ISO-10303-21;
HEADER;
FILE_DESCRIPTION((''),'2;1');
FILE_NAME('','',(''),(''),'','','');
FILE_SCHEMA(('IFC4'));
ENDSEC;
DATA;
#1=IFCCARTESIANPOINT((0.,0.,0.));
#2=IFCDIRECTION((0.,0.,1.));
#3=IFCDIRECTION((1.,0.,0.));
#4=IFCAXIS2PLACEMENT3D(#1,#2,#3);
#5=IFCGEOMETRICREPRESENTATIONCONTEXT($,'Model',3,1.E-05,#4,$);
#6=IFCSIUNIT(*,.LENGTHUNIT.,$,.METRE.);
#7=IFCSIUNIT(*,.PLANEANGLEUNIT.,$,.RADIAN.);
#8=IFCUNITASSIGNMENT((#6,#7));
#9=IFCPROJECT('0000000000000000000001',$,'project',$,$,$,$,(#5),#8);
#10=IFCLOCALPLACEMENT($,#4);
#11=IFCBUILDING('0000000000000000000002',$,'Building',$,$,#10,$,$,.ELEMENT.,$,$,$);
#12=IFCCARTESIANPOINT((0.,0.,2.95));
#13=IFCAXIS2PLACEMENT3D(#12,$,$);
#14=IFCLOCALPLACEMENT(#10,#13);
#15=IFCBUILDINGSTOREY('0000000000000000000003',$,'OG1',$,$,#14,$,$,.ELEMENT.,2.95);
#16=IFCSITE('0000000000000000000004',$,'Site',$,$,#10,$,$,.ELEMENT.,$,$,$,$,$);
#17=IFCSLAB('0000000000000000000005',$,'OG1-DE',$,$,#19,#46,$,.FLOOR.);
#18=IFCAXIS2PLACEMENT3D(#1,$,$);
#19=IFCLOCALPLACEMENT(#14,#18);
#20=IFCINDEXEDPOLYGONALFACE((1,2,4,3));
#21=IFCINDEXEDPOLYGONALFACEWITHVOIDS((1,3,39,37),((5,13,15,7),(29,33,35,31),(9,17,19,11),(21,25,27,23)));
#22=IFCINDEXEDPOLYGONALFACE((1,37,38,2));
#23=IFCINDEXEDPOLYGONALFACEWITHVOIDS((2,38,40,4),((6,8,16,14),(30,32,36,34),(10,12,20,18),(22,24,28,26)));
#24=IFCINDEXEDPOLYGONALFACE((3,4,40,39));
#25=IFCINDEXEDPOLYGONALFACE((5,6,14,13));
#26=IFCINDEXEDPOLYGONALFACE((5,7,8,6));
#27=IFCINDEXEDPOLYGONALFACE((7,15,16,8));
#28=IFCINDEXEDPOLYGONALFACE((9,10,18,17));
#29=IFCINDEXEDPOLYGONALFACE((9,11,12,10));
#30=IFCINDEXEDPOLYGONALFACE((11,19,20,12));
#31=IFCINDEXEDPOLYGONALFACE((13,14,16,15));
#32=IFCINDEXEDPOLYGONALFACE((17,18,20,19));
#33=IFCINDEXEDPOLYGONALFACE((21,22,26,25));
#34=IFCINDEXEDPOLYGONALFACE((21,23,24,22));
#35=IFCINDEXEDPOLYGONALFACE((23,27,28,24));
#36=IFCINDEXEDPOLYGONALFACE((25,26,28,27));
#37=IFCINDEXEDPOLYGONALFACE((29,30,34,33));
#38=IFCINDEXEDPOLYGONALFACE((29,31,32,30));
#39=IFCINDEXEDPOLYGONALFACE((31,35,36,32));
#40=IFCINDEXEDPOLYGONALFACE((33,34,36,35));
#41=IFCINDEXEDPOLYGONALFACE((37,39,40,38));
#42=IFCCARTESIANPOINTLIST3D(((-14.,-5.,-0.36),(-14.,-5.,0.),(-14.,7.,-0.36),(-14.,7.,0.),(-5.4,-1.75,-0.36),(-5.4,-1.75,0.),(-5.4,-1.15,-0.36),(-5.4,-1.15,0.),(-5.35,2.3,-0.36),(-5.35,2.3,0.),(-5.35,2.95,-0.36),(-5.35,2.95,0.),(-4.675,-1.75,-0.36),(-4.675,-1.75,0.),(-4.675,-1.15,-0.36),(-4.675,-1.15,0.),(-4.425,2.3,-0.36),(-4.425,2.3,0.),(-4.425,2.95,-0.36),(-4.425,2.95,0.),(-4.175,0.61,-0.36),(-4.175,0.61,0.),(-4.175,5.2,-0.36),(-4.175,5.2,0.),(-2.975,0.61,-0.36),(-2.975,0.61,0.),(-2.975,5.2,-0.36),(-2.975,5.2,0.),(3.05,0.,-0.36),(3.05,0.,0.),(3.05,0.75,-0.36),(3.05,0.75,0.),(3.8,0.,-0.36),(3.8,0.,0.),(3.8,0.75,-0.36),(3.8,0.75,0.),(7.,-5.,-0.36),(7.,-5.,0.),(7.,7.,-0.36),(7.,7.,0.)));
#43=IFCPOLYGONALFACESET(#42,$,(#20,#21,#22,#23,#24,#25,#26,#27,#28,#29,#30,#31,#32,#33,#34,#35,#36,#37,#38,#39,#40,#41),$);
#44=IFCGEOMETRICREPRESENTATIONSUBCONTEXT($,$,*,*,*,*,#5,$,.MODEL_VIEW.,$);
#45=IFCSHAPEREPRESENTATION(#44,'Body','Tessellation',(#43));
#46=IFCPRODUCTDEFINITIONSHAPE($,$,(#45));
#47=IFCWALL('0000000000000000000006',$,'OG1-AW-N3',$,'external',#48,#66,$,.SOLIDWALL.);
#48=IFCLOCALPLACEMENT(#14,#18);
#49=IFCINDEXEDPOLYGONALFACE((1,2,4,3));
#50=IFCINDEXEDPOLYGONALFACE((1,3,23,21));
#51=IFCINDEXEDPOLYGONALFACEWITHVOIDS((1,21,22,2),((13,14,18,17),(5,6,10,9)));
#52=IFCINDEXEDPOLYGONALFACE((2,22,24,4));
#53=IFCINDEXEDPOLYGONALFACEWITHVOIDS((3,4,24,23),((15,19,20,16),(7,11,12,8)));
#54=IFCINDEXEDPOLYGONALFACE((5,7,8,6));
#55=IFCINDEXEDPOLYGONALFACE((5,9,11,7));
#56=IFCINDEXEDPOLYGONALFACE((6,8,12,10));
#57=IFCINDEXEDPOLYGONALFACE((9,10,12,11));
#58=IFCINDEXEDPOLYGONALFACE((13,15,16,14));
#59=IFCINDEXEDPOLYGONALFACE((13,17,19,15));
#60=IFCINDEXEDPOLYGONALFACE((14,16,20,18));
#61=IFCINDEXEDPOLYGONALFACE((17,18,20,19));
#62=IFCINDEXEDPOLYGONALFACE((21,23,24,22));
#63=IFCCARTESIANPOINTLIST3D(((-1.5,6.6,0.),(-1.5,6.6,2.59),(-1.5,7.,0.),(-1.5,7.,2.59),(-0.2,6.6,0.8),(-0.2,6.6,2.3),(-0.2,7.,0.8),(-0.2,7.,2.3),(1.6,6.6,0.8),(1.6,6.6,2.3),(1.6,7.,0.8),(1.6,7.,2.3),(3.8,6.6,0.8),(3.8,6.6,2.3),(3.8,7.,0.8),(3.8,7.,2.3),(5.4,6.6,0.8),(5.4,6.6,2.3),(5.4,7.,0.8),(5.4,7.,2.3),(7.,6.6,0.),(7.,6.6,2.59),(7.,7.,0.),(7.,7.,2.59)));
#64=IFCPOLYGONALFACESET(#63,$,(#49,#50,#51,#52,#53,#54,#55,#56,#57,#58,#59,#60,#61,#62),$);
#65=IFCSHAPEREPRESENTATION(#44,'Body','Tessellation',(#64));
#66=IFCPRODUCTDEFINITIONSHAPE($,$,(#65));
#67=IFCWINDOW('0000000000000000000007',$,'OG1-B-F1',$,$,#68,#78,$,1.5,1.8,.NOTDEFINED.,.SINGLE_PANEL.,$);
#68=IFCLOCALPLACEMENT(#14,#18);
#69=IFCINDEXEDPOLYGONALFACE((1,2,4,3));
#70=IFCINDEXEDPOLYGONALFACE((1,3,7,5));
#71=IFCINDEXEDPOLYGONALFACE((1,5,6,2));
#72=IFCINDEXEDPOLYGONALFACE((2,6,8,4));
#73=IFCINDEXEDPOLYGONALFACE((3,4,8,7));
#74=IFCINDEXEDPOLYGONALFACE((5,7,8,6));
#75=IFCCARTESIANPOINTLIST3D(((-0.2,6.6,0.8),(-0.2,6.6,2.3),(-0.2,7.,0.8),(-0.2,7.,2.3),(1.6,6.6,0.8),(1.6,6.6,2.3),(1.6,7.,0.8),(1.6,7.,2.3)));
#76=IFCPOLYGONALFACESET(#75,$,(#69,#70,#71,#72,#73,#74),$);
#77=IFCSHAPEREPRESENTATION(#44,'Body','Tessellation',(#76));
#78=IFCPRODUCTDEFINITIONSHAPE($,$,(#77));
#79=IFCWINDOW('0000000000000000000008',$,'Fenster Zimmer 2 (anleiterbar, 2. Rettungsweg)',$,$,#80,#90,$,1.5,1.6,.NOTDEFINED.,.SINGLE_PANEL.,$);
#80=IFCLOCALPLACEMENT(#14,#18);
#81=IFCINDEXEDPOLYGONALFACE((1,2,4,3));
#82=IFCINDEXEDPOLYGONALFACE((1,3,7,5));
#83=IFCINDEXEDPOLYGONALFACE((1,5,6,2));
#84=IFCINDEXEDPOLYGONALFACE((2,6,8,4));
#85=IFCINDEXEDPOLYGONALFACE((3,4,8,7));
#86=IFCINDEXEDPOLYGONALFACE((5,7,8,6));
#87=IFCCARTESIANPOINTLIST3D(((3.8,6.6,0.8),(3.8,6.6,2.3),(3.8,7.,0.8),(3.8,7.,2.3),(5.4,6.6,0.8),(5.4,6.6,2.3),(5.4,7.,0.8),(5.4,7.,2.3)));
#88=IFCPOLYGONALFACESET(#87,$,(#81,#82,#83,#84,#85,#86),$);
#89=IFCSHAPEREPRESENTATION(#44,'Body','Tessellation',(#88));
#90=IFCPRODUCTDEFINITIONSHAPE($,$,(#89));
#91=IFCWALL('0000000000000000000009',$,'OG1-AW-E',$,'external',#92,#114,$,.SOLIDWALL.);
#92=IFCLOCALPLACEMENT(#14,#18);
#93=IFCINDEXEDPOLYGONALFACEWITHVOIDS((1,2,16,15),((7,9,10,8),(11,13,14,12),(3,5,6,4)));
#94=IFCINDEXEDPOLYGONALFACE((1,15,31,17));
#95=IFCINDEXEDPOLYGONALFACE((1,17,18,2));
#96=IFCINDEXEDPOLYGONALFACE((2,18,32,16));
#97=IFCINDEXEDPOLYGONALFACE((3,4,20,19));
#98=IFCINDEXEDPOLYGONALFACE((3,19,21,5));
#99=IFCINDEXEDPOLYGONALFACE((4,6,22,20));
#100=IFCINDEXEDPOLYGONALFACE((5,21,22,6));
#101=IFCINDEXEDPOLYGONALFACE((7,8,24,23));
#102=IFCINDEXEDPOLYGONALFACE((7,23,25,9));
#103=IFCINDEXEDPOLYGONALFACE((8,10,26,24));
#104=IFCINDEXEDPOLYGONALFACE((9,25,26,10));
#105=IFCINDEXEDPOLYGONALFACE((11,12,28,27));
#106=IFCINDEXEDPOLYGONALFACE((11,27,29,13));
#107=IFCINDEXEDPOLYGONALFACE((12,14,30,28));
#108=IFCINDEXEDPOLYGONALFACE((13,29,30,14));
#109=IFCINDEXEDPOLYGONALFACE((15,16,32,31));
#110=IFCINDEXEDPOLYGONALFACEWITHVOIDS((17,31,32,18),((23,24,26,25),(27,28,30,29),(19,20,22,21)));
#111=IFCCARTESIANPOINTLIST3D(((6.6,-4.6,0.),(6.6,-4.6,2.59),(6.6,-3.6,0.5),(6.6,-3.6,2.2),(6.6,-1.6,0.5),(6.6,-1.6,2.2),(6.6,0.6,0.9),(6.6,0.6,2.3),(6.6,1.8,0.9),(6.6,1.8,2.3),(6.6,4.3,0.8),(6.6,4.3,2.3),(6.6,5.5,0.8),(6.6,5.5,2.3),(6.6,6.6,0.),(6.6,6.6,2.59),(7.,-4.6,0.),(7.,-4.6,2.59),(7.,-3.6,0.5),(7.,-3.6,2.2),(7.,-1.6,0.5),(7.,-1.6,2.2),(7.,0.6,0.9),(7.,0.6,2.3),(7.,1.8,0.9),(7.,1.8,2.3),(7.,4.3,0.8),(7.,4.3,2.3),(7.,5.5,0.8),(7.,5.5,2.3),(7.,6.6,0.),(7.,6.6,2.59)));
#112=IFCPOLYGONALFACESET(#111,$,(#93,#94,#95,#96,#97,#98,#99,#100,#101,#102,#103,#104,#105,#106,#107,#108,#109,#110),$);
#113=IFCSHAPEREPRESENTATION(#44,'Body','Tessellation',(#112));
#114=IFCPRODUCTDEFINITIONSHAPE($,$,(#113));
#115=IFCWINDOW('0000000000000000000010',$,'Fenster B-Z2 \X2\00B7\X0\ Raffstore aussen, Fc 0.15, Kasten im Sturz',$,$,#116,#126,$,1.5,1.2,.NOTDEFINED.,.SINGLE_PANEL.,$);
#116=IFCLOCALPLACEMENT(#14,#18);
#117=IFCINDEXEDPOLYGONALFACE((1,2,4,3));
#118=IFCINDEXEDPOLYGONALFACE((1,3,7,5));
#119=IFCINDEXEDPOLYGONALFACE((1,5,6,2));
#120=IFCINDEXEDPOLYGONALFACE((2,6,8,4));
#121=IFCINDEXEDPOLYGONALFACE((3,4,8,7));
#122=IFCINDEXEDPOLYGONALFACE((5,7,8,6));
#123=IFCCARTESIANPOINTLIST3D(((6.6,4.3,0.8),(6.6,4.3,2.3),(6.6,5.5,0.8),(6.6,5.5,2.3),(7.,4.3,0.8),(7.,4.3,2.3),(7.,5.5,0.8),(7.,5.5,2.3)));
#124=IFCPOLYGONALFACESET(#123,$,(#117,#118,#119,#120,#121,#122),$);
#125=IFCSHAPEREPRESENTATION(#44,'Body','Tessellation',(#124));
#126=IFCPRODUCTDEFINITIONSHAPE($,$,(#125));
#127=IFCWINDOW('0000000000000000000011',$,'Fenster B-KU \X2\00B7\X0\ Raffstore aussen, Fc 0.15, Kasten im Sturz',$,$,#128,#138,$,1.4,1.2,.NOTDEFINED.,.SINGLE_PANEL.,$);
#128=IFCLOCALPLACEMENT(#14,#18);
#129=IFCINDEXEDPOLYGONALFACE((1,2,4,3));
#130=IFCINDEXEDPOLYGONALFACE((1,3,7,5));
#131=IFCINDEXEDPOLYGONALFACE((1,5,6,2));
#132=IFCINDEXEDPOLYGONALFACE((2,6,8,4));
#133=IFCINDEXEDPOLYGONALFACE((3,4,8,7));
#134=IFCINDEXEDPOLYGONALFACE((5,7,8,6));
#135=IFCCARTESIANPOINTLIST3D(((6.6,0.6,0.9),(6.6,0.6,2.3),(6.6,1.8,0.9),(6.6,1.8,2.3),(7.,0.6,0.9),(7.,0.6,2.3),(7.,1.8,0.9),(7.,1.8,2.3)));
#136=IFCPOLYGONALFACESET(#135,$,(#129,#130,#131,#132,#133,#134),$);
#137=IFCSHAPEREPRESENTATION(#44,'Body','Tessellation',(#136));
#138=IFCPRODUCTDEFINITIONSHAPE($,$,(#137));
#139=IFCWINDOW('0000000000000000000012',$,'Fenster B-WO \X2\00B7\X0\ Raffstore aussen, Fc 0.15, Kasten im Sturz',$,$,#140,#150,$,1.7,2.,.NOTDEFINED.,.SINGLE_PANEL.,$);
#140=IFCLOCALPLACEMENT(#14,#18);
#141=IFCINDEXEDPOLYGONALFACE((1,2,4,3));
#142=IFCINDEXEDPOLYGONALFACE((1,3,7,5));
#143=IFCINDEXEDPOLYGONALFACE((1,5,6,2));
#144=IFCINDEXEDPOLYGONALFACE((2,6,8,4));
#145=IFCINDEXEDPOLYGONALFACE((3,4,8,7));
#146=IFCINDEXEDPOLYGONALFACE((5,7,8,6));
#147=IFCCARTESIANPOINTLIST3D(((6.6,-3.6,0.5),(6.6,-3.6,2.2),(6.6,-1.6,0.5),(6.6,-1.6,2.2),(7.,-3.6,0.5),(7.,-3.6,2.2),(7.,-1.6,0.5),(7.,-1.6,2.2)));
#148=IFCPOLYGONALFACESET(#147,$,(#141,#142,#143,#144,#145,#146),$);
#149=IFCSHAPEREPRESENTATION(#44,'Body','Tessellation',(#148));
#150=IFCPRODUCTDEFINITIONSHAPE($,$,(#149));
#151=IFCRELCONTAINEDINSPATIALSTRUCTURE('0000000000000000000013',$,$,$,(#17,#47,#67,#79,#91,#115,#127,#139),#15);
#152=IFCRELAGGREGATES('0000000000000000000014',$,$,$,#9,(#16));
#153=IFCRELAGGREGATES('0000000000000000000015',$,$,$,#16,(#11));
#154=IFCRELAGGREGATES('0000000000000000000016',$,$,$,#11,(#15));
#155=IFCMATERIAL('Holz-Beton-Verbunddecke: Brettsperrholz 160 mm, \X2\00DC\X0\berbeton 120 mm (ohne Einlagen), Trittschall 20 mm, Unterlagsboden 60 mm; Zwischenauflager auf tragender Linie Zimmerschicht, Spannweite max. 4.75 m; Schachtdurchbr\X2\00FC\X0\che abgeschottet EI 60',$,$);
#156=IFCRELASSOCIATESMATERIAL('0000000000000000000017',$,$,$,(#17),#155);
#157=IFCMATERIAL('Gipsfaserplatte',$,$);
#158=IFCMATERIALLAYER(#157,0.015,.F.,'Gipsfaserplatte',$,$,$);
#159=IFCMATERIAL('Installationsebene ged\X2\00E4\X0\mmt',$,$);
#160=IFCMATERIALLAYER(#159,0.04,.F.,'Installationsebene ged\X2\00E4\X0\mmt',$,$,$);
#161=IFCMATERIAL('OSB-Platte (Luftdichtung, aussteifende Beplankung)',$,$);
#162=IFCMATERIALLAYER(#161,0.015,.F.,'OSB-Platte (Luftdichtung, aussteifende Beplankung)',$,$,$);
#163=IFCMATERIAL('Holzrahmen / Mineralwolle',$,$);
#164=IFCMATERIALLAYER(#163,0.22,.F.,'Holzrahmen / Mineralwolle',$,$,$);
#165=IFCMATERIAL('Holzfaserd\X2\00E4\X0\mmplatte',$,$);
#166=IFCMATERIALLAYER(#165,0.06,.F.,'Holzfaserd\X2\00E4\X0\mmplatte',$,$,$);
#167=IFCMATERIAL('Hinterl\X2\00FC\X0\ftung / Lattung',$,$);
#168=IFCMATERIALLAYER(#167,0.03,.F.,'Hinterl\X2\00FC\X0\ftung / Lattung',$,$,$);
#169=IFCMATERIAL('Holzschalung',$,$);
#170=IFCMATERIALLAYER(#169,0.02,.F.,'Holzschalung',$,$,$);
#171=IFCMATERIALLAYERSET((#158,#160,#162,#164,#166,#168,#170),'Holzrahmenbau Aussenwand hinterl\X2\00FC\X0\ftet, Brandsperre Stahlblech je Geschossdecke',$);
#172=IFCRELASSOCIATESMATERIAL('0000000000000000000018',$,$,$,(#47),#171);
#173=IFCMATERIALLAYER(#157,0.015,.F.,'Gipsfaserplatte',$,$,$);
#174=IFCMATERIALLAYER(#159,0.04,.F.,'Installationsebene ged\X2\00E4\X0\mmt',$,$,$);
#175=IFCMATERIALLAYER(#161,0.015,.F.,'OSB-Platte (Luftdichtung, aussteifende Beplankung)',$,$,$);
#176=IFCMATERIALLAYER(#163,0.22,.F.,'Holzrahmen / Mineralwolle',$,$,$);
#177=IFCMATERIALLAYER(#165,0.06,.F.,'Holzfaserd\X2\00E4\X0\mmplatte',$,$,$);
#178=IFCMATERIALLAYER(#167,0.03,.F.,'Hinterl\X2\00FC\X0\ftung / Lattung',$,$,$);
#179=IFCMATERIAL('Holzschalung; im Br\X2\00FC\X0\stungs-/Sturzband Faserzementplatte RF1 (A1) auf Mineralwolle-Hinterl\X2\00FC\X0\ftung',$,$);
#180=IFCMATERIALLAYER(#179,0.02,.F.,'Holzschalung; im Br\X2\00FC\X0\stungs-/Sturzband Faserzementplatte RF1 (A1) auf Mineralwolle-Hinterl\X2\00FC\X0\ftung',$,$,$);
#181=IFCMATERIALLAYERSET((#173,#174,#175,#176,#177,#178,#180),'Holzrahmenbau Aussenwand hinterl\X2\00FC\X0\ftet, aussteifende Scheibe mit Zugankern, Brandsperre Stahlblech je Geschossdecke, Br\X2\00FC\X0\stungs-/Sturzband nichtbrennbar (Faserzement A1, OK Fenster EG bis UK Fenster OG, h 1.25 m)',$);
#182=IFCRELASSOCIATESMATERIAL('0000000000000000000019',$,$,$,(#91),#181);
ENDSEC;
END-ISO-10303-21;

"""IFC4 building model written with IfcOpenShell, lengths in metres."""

from ifc_helpers import new_model, si_unit, frame, frame_2d, origin, origin_with_axes, origin_2d, place, context, subcontext, project, spatial, polyline, rectangle, outline, extrude, material, layer, layer_set, element, fill, save


model = new_model("IFC4")

# Units and contexts
model_context = context("Model", 3, precision=1e-05, world=origin_with_axes())
sub_context = subcontext(model_context, None, None, "MODEL_VIEW")
ifc_project = project(units=[si_unit("LENGTHUNIT", "METRE"), si_unit("PLANEANGLEUNIT", "RADIAN")], contexts=[model_context])

# Site, building, storey
placement = place(None, origin_with_axes())
site = spatial("IfcSite", under=ifc_project, at=placement, Name="Site", CompositionType="ELEMENT")
building = spatial("IfcBuilding", under=site, at=placement, Name="Building", CompositionType="ELEMENT")
storey_placement = place(placement, frame((0.0, 0.0, 2.95)))
storey = spatial("IfcBuildingStorey", under=building, at=storey_placement, Name="OG1", CompositionType="ELEMENT", Elevation=2.95)

# Slab, openings
ifc_material_1 = material(Name="Holz-Beton-Verbunddecke: Brettsperrholz 160 mm, Überbeton 120 mm (ohne Einlagen), Trittschall 20 mm, Unterlagsboden 60 mm; Zwischenauflager auf tragender Linie Zimmerschicht, Spannweite max. 4.75 m; Schachtdurchbrüche abgeschottet EI 60")
slab_placement = place(storey_placement, frame((0.0, 0.0, -0.36)))
slab = element("IfcSlab", 1, at=slab_placement, inside=storey, material=ifc_material_1, Name="OG1-DE", PredefinedType="FLOOR", context=sub_context, shape_type="SweptSolid", body=[
    extrude(outline(polyline([(-14.0, -5.0), (7.0, -5.0), (7.0, 7.0), (-14.0, 7.0), (-14.0, -5.0)])), origin(), (0.0, 0.0, 1.0), 0.36),
])
opening_1_placement = place(slab_placement, frame((-3.575, 2.905, 0.0)))
element("IfcOpeningElement", 2, at=opening_1_placement, cuts=slab, PredefinedType="OPENING", context=sub_context, shape_type="SweptSolid", body=[
    extrude(rectangle(XDim=1.2, YDim=4.59, at=origin_2d()), origin(), (0.0, 0.0, 1.0), 0.46),
])
opening_2_placement = place(slab_placement, frame((-4.8875, 2.625, 0.0)))
element("IfcOpeningElement", 3, at=opening_2_placement, cuts=slab, PredefinedType="OPENING", context=sub_context, shape_type="SweptSolid", body=[
    extrude(rectangle(XDim=0.925, YDim=0.65, at=origin_2d()), origin(), (0.0, 0.0, 1.0), 0.46),
])
opening_3_placement = place(slab_placement, frame((3.425, 0.375, 0.0)))
element("IfcOpeningElement", 4, at=opening_3_placement, cuts=slab, PredefinedType="OPENING", context=sub_context, shape_type="SweptSolid", body=[
    extrude(rectangle(XDim=0.75, YDim=0.75, at=origin_2d()), origin(), (0.0, 0.0, 1.0), 0.46),
])
opening_4_placement = place(slab_placement, frame((-5.0375, -1.45, 0.0)))
element("IfcOpeningElement", 5, at=opening_4_placement, cuts=slab, PredefinedType="OPENING", context=sub_context, shape_type="SweptSolid", body=[
    extrude(rectangle(XDim=0.725, YDim=0.6, at=origin_2d()), origin(), (0.0, 0.0, 1.0), 0.46),
])

# Walls, openings, windows
ifc_material_2 = material(Name="Gipsfaserplatte")
ifc_layer_1 = layer(ifc_material_2, 0.015, ventilated=False, Name="Gipsfaserplatte")
ifc_material_3 = material(Name="Installationsebene gedämmt")
ifc_layer_2 = layer(ifc_material_3, 0.04, ventilated=False, Name="Installationsebene gedämmt")
ifc_material_4 = material(Name="OSB-Platte (Luftdichtung, aussteifende Beplankung)")
ifc_layer_3 = layer(ifc_material_4, 0.015, ventilated=False, Name="OSB-Platte (Luftdichtung, aussteifende Beplankung)")
ifc_material_5 = material(Name="Holzrahmen / Mineralwolle")
ifc_layer_4 = layer(ifc_material_5, 0.22, ventilated=False, Name="Holzrahmen / Mineralwolle")
ifc_material_6 = material(Name="Holzfaserdämmplatte")
ifc_layer_5 = layer(ifc_material_6, 0.06, ventilated=False, Name="Holzfaserdämmplatte")
ifc_material_7 = material(Name="Hinterlüftung / Lattung")
ifc_layer_6 = layer(ifc_material_7, 0.03, ventilated=False, Name="Hinterlüftung / Lattung")
ifc_material_8 = material(Name="Holzschalung")
ifc_layer_7 = layer(ifc_material_8, 0.02, ventilated=False, Name="Holzschalung")
ifc_layer_set_1 = layer_set([ifc_layer_1, ifc_layer_2, ifc_layer_3, ifc_layer_4, ifc_layer_5, ifc_layer_6, ifc_layer_7], Name="Holzrahmenbau Aussenwand hinterlüftet, Brandsperre Stahlblech je Geschossdecke")
wall_1_placement = place(storey_placement, frame((-1.5, 6.8, 0.0), z_axis=(0.0, 0.0, 1.0), x_axis=(1.0, 0.0, 0.0)))
wall_1 = element("IfcWall", 6, at=wall_1_placement, inside=storey, material=ifc_layer_set_1, Name="OG1-AW-N3", ObjectType="external", PredefinedType="SOLIDWALL", context=sub_context, shape_type="SweptSolid", body=[
    extrude(rectangle(XDim=8.5, YDim=0.4, at=frame_2d((4.25, 0.0))), origin(), (0.0, 0.0, 1.0), 2.59),
])
opening_5_placement = place(wall_1_placement, frame((2.2, 0.25, 0.8), z_axis=(0.0, -1.0, 0.0), x_axis=(1.0, 0.0, 0.0)))
opening_5 = element("IfcOpeningElement", 7, at=opening_5_placement, cuts=wall_1, PredefinedType="OPENING", context=sub_context, shape_type="SweptSolid", body=[
    extrude(rectangle(XDim=1.8, YDim=1.5, at=frame_2d((0.0, 0.75))), origin(), (0.0, 0.0, 1.0), 0.5),
])
opening_6_placement = place(wall_1_placement, frame((6.1, 0.25, 0.8), z_axis=(0.0, -1.0, 0.0), x_axis=(1.0, 0.0, 0.0)))
opening_6 = element("IfcOpeningElement", 8, at=opening_6_placement, cuts=wall_1, PredefinedType="OPENING", context=sub_context, shape_type="SweptSolid", body=[
    extrude(rectangle(XDim=1.6, YDim=1.5, at=frame_2d((0.0, 0.75))), origin(), (0.0, 0.0, 1.0), 0.5),
])
window_1_placement = place(wall_1_placement, frame((2.2, 0.2, 0.8), z_axis=(0.0, -1.0, 0.0), x_axis=(1.0, 0.0, 0.0)))
window_1 = element("IfcWindow", 9, at=window_1_placement, inside=storey, Name="OG1-B-F1", OverallHeight=1.5, OverallWidth=1.8, PartitioningType="SINGLE_PANEL", PredefinedType="NOTDEFINED", context=sub_context, shape_type="SweptSolid", body=[
    extrude(rectangle(XDim=1.8, YDim=1.5, at=frame_2d((0.0, 0.75))), origin(), (0.0, 0.0, 1.0), 0.4),
])
fill(opening_5, window_1)
window_2_placement = place(wall_1_placement, frame((6.1, 0.2, 0.8), z_axis=(0.0, -1.0, 0.0), x_axis=(1.0, 0.0, 0.0)))
window_2 = element("IfcWindow", 10, at=window_2_placement, inside=storey, Name="Fenster Zimmer 2 (anleiterbar, 2. Rettungsweg)", OverallHeight=1.5, OverallWidth=1.6, PartitioningType="SINGLE_PANEL", PredefinedType="NOTDEFINED", context=sub_context, shape_type="SweptSolid", body=[
    extrude(rectangle(XDim=1.6, YDim=1.5, at=frame_2d((0.0, 0.75))), origin(), (0.0, 0.0, 1.0), 0.4),
])
fill(opening_6, window_2)
ifc_layer_8 = layer(ifc_material_2, 0.015, ventilated=False, Name="Gipsfaserplatte")
ifc_layer_9 = layer(ifc_material_3, 0.04, ventilated=False, Name="Installationsebene gedämmt")
ifc_layer_10 = layer(ifc_material_4, 0.015, ventilated=False, Name="OSB-Platte (Luftdichtung, aussteifende Beplankung)")
ifc_layer_11 = layer(ifc_material_5, 0.22, ventilated=False, Name="Holzrahmen / Mineralwolle")
ifc_layer_12 = layer(ifc_material_6, 0.06, ventilated=False, Name="Holzfaserdämmplatte")
ifc_layer_13 = layer(ifc_material_7, 0.03, ventilated=False, Name="Hinterlüftung / Lattung")
ifc_material_9 = material(Name="Holzschalung; im Brüstungs-/Sturzband Faserzementplatte RF1 (A1) auf Mineralwolle-Hinterlüftung")
ifc_layer_14 = layer(ifc_material_9, 0.02, ventilated=False, Name="Holzschalung; im Brüstungs-/Sturzband Faserzementplatte RF1 (A1) auf Mineralwolle-Hinterlüftung")
ifc_layer_set_2 = layer_set([ifc_layer_8, ifc_layer_9, ifc_layer_10, ifc_layer_11, ifc_layer_12, ifc_layer_13, ifc_layer_14], Name="Holzrahmenbau Aussenwand hinterlüftet, aussteifende Scheibe mit Zugankern, Brandsperre Stahlblech je Geschossdecke, Brüstungs-/Sturzband nichtbrennbar (Faserzement A1, OK Fenster EG bis UK Fenster OG, h 1.25 m)")
wall_2_placement = place(storey_placement, frame((6.8, 6.6, 0.0), z_axis=(0.0, 0.0, 1.0), x_axis=(0.0, -1.0, 0.0)))
wall_2 = element("IfcWall", 11, at=wall_2_placement, inside=storey, material=ifc_layer_set_2, Name="OG1-AW-E", ObjectType="external", PredefinedType="SOLIDWALL", context=sub_context, shape_type="SweptSolid", body=[
    extrude(rectangle(XDim=11.2, YDim=0.4, at=frame_2d((5.6, 0.0))), origin(), (0.0, 0.0, 1.0), 2.59),
])
opening_7_placement = place(wall_2_placement, frame((1.7, 0.25, 0.8), z_axis=(0.0, -1.0, 0.0), x_axis=(1.0, 0.0, 0.0)))
opening_7 = element("IfcOpeningElement", 12, at=opening_7_placement, cuts=wall_2, PredefinedType="OPENING", context=sub_context, shape_type="SweptSolid", body=[
    extrude(rectangle(XDim=1.2, YDim=1.5, at=frame_2d((0.0, 0.75))), origin(), (0.0, 0.0, 1.0), 0.5),
])
opening_8_placement = place(wall_2_placement, frame((5.4, 0.25, 0.9), z_axis=(0.0, -1.0, 0.0), x_axis=(1.0, 0.0, 0.0)))
opening_8 = element("IfcOpeningElement", 13, at=opening_8_placement, cuts=wall_2, PredefinedType="OPENING", context=sub_context, shape_type="SweptSolid", body=[
    extrude(rectangle(XDim=1.2, YDim=1.4, at=frame_2d((0.0, 0.7))), origin(), (0.0, 0.0, 1.0), 0.5),
])
opening_9_placement = place(wall_2_placement, frame((9.2, 0.25, 0.5), z_axis=(0.0, -1.0, 0.0), x_axis=(1.0, 0.0, 0.0)))
opening_9 = element("IfcOpeningElement", 14, at=opening_9_placement, cuts=wall_2, PredefinedType="OPENING", context=sub_context, shape_type="SweptSolid", body=[
    extrude(rectangle(XDim=2.0, YDim=1.7, at=frame_2d((0.0, 0.85))), origin(), (0.0, 0.0, 1.0), 0.5),
])
window_3_placement = place(wall_2_placement, frame((1.7, 0.2, 0.8), z_axis=(0.0, -1.0, 0.0), x_axis=(1.0, 0.0, 0.0)))
window_3 = element("IfcWindow", 15, at=window_3_placement, inside=storey, Name="Fenster B-Z2 · Raffstore aussen, Fc 0.15, Kasten im Sturz", OverallHeight=1.5, OverallWidth=1.2, PartitioningType="SINGLE_PANEL", PredefinedType="NOTDEFINED", context=sub_context, shape_type="SweptSolid", body=[
    extrude(rectangle(XDim=1.2, YDim=1.5, at=frame_2d((0.0, 0.75))), origin(), (0.0, 0.0, 1.0), 0.4),
])
fill(opening_7, window_3)
window_4_placement = place(wall_2_placement, frame((5.4, 0.2, 0.9), z_axis=(0.0, -1.0, 0.0), x_axis=(1.0, 0.0, 0.0)))
window_4 = element("IfcWindow", 16, at=window_4_placement, inside=storey, Name="Fenster B-KU · Raffstore aussen, Fc 0.15, Kasten im Sturz", OverallHeight=1.4, OverallWidth=1.2, PartitioningType="SINGLE_PANEL", PredefinedType="NOTDEFINED", context=sub_context, shape_type="SweptSolid", body=[
    extrude(rectangle(XDim=1.2, YDim=1.4, at=frame_2d((0.0, 0.7))), origin(), (0.0, 0.0, 1.0), 0.4),
])
fill(opening_8, window_4)
window_5_placement = place(wall_2_placement, frame((9.2, 0.2, 0.5), z_axis=(0.0, -1.0, 0.0), x_axis=(1.0, 0.0, 0.0)))
window_5 = element("IfcWindow", 17, at=window_5_placement, inside=storey, Name="Fenster B-WO · Raffstore aussen, Fc 0.15, Kasten im Sturz", OverallHeight=1.7, OverallWidth=2.0, PartitioningType="SINGLE_PANEL", PredefinedType="NOTDEFINED", context=sub_context, shape_type="SweptSolid", body=[
    extrude(rectangle(XDim=2.0, YDim=1.7, at=frame_2d((0.0, 0.85))), origin(), (0.0, 0.0, 1.0), 0.4),
])
fill(opening_9, window_5)

save(model, "model.ifc")
